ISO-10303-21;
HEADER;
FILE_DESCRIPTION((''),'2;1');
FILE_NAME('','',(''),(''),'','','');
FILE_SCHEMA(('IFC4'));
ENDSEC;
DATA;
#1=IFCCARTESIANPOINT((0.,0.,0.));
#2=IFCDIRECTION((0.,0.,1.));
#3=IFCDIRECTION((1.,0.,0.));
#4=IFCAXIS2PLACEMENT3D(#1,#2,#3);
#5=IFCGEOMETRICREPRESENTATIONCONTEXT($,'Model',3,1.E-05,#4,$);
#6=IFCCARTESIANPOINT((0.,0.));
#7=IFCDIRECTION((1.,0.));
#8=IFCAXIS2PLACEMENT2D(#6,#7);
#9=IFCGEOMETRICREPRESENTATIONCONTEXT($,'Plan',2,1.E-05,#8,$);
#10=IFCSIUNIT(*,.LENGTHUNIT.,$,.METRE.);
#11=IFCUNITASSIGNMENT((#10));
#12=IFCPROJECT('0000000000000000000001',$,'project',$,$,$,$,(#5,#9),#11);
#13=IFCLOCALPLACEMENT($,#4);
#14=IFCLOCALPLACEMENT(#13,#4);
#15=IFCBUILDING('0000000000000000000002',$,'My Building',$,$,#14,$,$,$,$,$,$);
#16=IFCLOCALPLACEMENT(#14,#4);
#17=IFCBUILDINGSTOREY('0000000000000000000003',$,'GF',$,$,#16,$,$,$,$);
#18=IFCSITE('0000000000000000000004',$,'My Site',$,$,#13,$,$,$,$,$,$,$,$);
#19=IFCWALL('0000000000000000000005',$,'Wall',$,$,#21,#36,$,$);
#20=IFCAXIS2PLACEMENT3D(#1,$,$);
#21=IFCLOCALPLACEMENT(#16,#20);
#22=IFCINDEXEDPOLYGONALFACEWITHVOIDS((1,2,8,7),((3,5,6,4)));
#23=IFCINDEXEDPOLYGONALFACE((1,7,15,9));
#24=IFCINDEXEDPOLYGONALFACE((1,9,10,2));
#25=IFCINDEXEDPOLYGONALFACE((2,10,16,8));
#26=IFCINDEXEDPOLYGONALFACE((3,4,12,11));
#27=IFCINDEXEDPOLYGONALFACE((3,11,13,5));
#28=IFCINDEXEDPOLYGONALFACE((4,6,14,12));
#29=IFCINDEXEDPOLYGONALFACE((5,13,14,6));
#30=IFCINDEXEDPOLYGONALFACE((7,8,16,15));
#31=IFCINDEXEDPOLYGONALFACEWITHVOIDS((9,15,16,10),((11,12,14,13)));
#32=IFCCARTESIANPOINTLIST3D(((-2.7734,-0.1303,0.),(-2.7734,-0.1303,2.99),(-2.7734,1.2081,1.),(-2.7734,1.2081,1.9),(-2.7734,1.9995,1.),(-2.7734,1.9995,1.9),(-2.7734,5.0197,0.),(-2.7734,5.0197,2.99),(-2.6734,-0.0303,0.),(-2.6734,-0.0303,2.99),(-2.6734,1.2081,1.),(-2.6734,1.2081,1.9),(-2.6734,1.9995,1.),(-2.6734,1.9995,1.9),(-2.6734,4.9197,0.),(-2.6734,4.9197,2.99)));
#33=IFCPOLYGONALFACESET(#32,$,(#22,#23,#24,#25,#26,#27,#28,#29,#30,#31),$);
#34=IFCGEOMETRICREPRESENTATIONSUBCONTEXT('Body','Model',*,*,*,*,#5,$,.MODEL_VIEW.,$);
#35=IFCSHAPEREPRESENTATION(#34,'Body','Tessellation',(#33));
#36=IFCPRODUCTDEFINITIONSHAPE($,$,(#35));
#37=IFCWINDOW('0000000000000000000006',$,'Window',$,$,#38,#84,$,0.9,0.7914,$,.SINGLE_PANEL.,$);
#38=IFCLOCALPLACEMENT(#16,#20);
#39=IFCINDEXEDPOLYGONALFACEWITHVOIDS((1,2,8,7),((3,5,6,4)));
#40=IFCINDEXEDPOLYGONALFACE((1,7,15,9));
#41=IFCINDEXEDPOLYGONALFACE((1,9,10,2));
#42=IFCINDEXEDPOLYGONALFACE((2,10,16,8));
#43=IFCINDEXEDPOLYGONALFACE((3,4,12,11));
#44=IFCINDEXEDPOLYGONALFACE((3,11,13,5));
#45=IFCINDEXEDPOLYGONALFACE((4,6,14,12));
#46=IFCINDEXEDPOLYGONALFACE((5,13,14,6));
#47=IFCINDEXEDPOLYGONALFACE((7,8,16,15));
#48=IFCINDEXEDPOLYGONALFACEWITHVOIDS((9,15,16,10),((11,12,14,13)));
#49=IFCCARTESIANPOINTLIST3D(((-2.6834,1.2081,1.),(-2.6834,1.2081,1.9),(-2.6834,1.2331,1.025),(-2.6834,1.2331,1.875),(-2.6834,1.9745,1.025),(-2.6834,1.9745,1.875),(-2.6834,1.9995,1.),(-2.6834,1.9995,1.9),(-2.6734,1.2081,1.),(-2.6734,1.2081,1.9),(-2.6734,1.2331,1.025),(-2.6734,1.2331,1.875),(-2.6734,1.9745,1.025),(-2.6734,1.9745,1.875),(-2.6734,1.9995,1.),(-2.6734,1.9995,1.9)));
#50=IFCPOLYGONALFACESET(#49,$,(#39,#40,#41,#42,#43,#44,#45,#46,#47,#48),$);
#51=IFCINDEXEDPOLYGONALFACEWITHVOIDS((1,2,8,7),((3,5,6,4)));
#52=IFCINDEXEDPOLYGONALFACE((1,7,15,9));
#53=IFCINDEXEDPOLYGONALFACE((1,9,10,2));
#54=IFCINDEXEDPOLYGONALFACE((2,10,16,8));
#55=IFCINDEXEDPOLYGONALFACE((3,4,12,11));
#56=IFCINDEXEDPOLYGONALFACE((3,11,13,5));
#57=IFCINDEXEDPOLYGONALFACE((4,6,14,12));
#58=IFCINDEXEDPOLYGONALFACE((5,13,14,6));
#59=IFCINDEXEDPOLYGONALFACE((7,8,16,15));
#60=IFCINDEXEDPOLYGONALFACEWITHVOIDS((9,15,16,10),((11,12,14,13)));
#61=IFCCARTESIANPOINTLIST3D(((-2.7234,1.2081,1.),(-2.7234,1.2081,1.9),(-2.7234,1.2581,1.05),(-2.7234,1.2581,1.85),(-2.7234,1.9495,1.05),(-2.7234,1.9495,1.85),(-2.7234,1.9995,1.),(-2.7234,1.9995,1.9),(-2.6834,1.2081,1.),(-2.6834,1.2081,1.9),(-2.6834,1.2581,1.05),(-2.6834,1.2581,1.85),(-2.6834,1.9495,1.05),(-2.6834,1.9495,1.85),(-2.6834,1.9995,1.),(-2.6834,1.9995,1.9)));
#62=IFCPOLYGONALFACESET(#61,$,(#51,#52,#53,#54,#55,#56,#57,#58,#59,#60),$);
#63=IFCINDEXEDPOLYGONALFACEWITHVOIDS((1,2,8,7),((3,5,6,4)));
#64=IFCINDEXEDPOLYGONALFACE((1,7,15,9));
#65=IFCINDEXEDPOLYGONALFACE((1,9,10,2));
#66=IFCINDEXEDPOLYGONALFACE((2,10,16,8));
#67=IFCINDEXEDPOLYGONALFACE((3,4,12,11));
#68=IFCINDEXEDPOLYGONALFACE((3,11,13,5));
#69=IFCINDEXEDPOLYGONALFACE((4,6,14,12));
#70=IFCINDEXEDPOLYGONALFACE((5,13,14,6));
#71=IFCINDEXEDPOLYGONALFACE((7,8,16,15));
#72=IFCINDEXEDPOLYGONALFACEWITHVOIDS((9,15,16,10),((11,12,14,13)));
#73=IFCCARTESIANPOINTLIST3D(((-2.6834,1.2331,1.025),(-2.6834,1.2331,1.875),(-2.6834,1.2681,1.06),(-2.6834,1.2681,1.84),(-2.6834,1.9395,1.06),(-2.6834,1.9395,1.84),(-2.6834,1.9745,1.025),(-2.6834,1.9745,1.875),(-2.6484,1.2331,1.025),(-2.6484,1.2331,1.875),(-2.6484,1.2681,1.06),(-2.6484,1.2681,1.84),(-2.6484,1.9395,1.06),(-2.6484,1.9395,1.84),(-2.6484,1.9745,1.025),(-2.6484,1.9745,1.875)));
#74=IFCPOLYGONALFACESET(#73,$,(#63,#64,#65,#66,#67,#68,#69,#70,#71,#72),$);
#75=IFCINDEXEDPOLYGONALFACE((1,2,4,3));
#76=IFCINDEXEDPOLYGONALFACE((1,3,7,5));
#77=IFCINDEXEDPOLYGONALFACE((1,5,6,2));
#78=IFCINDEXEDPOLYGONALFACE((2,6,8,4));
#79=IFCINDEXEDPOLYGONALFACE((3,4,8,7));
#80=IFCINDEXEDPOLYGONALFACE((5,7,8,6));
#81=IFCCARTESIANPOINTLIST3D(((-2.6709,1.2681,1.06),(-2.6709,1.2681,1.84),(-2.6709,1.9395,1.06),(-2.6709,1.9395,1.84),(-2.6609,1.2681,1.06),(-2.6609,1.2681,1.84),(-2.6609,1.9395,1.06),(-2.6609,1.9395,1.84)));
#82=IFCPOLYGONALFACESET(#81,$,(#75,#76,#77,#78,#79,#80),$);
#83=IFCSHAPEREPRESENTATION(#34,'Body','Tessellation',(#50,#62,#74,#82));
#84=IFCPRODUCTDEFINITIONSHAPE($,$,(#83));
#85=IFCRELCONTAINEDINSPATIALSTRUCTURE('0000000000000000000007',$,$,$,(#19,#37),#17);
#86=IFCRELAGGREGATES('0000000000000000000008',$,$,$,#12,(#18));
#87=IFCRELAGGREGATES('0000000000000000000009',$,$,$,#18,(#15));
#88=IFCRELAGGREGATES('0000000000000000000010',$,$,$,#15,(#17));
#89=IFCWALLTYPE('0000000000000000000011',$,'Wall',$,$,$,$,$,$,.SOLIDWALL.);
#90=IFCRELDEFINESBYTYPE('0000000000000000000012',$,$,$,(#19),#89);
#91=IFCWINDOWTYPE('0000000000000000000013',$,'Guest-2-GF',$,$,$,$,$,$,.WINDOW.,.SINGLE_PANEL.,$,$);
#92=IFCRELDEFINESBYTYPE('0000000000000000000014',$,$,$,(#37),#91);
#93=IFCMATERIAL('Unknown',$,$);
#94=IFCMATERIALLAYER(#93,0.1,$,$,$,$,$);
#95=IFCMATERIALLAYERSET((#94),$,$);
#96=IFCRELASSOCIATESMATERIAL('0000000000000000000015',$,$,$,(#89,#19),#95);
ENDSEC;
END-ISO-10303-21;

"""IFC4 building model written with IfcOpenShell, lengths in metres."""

from ifc_helpers import new_model, entity, si_unit, frame, origin_with_axes, origin_2d_with_axis, place, context, subcontext, project, spatial, line, indexed_curve, outline, extrude, shape, source, transform, mapped, material, layer, layer_set, layer_usage, type_object, type_shapes, element, fill, save


model = new_model("IFC4")

# Units and contexts
model_context = context("Model", 3, precision=1e-05, world=origin_with_axes())
plan_context = context("Plan", 2, precision=1e-05, world=origin_2d_with_axis())
body_context_1 = subcontext(model_context, "Body", "Model", "MODEL_VIEW")
body_context_2 = subcontext(plan_context, "Body", "Plan", "PLAN_VIEW")
ifc_project = project(units=[si_unit("LENGTHUNIT", "METRE")], contexts=[model_context, plan_context])

# Site, building, storey
site_placement = place(None, origin_with_axes())
site = spatial("IfcSite", under=ifc_project, at=site_placement, Name="My Site")
building_placement = place(site_placement, origin_with_axes())
building = spatial("IfcBuilding", under=site, at=building_placement, Name="My Building")
storey_placement = place(building_placement, origin_with_axes())
storey = spatial("IfcBuildingStorey", under=building, at=storey_placement, Name="GF")

# Shared definitions
ifc_material = material(Name="Unknown")

# Shared definitions
ifc_layer_1 = layer(ifc_material, 0.1)
ifc_layer_set_1 = layer_set([ifc_layer_1])
wall_type = type_object("IfcWallType", Name="Wall", PredefinedType="SOLIDWALL", material=ifc_layer_set_1)

# Wall, opening, window
ifc_layer_usage_1 = layer_usage(ifc_layer_set_1, "AXIS2", "POSITIVE", 0.0)
wall_1_placement = place(storey_placement, frame((-2.7734, 5.0197, 0.0), z_axis=(0.0, 0.0, 1.0), x_axis=(0.0, -1.0, 0.0)))
wall_1 = element("IfcWall", 1, at=wall_1_placement, inside=storey, type_object=wall_type, material=ifc_layer_usage_1, Name="Wall", context=body_context_1, shape_type="SweptSolid", body=[
    extrude(outline(indexed_curve([(0.0, 0.0), (0.1, 0.1), (5.05, 0.1), (5.15, 0.0)], segments=[line(1, 2, 3, 4, 1)])), origin_with_axes(), (0.0, 0.0, 1.0), 2.99),
])
shared_shape_1 = source(origin_with_axes(), body_context_1, "Body", "SweptSolid", [
    extrude(outline(indexed_curve([(0.0, 0.0), (0.7914, 0.0), (0.7914, 0.9), (0.0, 0.9)], segments=[line(1, 2, 3, 4, 1)])), frame((0.0, -0.6, 0.0), z_axis=(0.0, -1.0, 0.0), x_axis=(1.0, 0.0, 0.0)), (0.0, 0.0, -1.0), 1.2),
])
opening_1_placement = place(wall_1_placement, frame((3.0202, 0.0, 1.0), z_axis=(0.0, 0.0, 1.0), x_axis=(1.0, 0.0, 0.0)))
opening_1 = element("IfcOpeningElement", 2, at=opening_1_placement, cuts=wall_1, PredefinedType="OPENING", context=body_context_1, shape_type="MappedRepresentation", body=[
    mapped(shared_shape_1, transform((0.0, 0.0, 0.0), x_axis=(1.0, 0.0, 0.0), y_axis=(0.0, 1.0, 0.0), z_axis=(0.0, 0.0, 1.0), scale=1.0)),
])
window_type_1 = type_object("IfcWindowType", Name="Guest-2-GF", PartitioningType="SINGLE_PANEL", PredefinedType="WINDOW")
shared_shape_2 = source(origin_with_axes(), body_context_1, "Body", "SweptSolid", [
    extrude(outline(indexed_curve([(0.0, 0.0), (0.7914, 0.0), (0.7914, 0.9), (0.0, 0.9)], segments=[line(1, 2, 3, 4, 1)]), holes=[indexed_curve([(0.025, 0.025), (0.7664, 0.025), (0.7664, 0.875), (0.025, 0.875)], segments=[line(1, 2, 3, 4, 1)])]), frame((0.0, 0.09, 0.0), z_axis=(0.0, -1.0, 0.0), x_axis=(1.0, 0.0, 0.0)), (0.0, 0.0, -1.0), 0.01),
    extrude(outline(indexed_curve([(0.0, 0.0), (0.7914, 0.0), (0.7914, 0.9), (0.0, 0.9)], segments=[line(1, 2, 3, 4, 1)]), holes=[indexed_curve([(0.05, 0.05), (0.7414, 0.05), (0.7414, 0.85), (0.05, 0.85)], segments=[line(1, 2, 3, 4, 1)])]), frame((0.0, 0.05, 0.0), z_axis=(0.0, -1.0, 0.0), x_axis=(1.0, 0.0, 0.0)), (0.0, 0.0, -1.0), 0.04),
    extrude(outline(indexed_curve([(0.0, 0.0), (0.7414, 0.0), (0.7414, 0.85), (0.0, 0.85)], segments=[line(1, 2, 3, 4, 1)]), holes=[indexed_curve([(0.035, 0.035), (0.7064, 0.035), (0.7064, 0.815), (0.035, 0.815)], segments=[line(1, 2, 3, 4, 1)])]), frame((0.025, 0.09, 0.025), z_axis=(0.0, -1.0, 0.0), x_axis=(1.0, 0.0, 0.0)), (0.0, 0.0, -1.0), 0.035),
    extrude(outline(indexed_curve([(0.035, 0.035), (0.7064, 0.035), (0.7064, 0.815), (0.035, 0.815)], segments=[line(1, 2, 3, 4, 1)])), frame((0.025, 0.1025, 0.025), z_axis=(0.0, -1.0, 0.0), x_axis=(1.0, 0.0, 0.0)), (0.0, 0.0, -1.0), 0.01),
])
shared_shape_3 = source(origin_with_axes(), body_context_2, "Body", "Curve2D", [
    entity("IfcIndexedPolyCurve", entity("IfcCartesianPointList2D", [[0.05, 0.05], [0.7414, 0.05]])),
    entity("IfcIndexedPolyCurve", entity("IfcCartesianPointList2D", [[0.0, 0.1], [0.025, 0.1], [0.025, 0.09], [0.05, 0.09], [0.05, 0.05], [0.0, 0.05]]), [entity("IfcLineIndex", [1, 2, 3, 4, 5, 6, 1])]),
    entity("IfcIndexedPolyCurve", entity("IfcCartesianPointList2D", [[0.7914, 0.1], [0.7664, 0.1], [0.7664, 0.09], [0.7414, 0.09], [0.7414, 0.05], [0.7914, 0.05]]), [entity("IfcLineIndex", [1, 2, 3, 4, 5, 6, 1])]),
    entity("IfcIndexedPolyCurve", entity("IfcCartesianPointList2D", [[0.025, 0.09], [0.06, 0.09], [0.06, 0.125], [0.025, 0.125]]), [entity("IfcLineIndex", [1, 2, 3, 4, 1])]),
    entity("IfcIndexedPolyCurve", entity("IfcCartesianPointList2D", [[0.7664, 0.09], [0.7314, 0.09], [0.7314, 0.125], [0.7664, 0.125]]), [entity("IfcLineIndex", [1, 2, 3, 4, 1])]),
    entity("IfcIndexedPolyCurve", entity("IfcCartesianPointList2D", [[0.06, 0.09], [0.7314, 0.09]])),
    entity("IfcIndexedPolyCurve", entity("IfcCartesianPointList2D", [[0.06, 0.125], [0.7314, 0.125]])),
    entity("IfcIndexedPolyCurve", entity("IfcCartesianPointList2D", [[0.06, 0.1075], [0.7314, 0.1075]])),
])
type_shapes(window_type_1, [shared_shape_2, shared_shape_3])
window_1_placement = place(opening_1_placement, frame((0.0, 0.0, 0.0), z_axis=(0.0, 0.0, 1.0), x_axis=(1.0, 0.0, 0.0)))
window_1 = element("IfcWindow", 3, at=window_1_placement, inside=storey, type_object=window_type_1, Name="Window", OverallHeight=0.9, OverallWidth=0.7914, PartitioningType="SINGLE_PANEL", shapes=[
    shape(body_context_1, "Body", "MappedRepresentation", [mapped(shared_shape_2, transform((0.0, 0.0, 0.0), x_axis=(1.0, 0.0, 0.0), y_axis=(0.0, 1.0, 0.0), z_axis=(0.0, 0.0, 1.0), scale=1.0))]),
    shape(body_context_2, "Body", "MappedRepresentation", [mapped(shared_shape_3, transform((0.0, 0.0, 0.0), x_axis=(1.0, 0.0, 0.0), y_axis=(0.0, 1.0, 0.0), z_axis=(0.0, 0.0, 1.0), scale=1.0))]),
])
fill(opening_1, window_1)

save(model, "model.ifc")
